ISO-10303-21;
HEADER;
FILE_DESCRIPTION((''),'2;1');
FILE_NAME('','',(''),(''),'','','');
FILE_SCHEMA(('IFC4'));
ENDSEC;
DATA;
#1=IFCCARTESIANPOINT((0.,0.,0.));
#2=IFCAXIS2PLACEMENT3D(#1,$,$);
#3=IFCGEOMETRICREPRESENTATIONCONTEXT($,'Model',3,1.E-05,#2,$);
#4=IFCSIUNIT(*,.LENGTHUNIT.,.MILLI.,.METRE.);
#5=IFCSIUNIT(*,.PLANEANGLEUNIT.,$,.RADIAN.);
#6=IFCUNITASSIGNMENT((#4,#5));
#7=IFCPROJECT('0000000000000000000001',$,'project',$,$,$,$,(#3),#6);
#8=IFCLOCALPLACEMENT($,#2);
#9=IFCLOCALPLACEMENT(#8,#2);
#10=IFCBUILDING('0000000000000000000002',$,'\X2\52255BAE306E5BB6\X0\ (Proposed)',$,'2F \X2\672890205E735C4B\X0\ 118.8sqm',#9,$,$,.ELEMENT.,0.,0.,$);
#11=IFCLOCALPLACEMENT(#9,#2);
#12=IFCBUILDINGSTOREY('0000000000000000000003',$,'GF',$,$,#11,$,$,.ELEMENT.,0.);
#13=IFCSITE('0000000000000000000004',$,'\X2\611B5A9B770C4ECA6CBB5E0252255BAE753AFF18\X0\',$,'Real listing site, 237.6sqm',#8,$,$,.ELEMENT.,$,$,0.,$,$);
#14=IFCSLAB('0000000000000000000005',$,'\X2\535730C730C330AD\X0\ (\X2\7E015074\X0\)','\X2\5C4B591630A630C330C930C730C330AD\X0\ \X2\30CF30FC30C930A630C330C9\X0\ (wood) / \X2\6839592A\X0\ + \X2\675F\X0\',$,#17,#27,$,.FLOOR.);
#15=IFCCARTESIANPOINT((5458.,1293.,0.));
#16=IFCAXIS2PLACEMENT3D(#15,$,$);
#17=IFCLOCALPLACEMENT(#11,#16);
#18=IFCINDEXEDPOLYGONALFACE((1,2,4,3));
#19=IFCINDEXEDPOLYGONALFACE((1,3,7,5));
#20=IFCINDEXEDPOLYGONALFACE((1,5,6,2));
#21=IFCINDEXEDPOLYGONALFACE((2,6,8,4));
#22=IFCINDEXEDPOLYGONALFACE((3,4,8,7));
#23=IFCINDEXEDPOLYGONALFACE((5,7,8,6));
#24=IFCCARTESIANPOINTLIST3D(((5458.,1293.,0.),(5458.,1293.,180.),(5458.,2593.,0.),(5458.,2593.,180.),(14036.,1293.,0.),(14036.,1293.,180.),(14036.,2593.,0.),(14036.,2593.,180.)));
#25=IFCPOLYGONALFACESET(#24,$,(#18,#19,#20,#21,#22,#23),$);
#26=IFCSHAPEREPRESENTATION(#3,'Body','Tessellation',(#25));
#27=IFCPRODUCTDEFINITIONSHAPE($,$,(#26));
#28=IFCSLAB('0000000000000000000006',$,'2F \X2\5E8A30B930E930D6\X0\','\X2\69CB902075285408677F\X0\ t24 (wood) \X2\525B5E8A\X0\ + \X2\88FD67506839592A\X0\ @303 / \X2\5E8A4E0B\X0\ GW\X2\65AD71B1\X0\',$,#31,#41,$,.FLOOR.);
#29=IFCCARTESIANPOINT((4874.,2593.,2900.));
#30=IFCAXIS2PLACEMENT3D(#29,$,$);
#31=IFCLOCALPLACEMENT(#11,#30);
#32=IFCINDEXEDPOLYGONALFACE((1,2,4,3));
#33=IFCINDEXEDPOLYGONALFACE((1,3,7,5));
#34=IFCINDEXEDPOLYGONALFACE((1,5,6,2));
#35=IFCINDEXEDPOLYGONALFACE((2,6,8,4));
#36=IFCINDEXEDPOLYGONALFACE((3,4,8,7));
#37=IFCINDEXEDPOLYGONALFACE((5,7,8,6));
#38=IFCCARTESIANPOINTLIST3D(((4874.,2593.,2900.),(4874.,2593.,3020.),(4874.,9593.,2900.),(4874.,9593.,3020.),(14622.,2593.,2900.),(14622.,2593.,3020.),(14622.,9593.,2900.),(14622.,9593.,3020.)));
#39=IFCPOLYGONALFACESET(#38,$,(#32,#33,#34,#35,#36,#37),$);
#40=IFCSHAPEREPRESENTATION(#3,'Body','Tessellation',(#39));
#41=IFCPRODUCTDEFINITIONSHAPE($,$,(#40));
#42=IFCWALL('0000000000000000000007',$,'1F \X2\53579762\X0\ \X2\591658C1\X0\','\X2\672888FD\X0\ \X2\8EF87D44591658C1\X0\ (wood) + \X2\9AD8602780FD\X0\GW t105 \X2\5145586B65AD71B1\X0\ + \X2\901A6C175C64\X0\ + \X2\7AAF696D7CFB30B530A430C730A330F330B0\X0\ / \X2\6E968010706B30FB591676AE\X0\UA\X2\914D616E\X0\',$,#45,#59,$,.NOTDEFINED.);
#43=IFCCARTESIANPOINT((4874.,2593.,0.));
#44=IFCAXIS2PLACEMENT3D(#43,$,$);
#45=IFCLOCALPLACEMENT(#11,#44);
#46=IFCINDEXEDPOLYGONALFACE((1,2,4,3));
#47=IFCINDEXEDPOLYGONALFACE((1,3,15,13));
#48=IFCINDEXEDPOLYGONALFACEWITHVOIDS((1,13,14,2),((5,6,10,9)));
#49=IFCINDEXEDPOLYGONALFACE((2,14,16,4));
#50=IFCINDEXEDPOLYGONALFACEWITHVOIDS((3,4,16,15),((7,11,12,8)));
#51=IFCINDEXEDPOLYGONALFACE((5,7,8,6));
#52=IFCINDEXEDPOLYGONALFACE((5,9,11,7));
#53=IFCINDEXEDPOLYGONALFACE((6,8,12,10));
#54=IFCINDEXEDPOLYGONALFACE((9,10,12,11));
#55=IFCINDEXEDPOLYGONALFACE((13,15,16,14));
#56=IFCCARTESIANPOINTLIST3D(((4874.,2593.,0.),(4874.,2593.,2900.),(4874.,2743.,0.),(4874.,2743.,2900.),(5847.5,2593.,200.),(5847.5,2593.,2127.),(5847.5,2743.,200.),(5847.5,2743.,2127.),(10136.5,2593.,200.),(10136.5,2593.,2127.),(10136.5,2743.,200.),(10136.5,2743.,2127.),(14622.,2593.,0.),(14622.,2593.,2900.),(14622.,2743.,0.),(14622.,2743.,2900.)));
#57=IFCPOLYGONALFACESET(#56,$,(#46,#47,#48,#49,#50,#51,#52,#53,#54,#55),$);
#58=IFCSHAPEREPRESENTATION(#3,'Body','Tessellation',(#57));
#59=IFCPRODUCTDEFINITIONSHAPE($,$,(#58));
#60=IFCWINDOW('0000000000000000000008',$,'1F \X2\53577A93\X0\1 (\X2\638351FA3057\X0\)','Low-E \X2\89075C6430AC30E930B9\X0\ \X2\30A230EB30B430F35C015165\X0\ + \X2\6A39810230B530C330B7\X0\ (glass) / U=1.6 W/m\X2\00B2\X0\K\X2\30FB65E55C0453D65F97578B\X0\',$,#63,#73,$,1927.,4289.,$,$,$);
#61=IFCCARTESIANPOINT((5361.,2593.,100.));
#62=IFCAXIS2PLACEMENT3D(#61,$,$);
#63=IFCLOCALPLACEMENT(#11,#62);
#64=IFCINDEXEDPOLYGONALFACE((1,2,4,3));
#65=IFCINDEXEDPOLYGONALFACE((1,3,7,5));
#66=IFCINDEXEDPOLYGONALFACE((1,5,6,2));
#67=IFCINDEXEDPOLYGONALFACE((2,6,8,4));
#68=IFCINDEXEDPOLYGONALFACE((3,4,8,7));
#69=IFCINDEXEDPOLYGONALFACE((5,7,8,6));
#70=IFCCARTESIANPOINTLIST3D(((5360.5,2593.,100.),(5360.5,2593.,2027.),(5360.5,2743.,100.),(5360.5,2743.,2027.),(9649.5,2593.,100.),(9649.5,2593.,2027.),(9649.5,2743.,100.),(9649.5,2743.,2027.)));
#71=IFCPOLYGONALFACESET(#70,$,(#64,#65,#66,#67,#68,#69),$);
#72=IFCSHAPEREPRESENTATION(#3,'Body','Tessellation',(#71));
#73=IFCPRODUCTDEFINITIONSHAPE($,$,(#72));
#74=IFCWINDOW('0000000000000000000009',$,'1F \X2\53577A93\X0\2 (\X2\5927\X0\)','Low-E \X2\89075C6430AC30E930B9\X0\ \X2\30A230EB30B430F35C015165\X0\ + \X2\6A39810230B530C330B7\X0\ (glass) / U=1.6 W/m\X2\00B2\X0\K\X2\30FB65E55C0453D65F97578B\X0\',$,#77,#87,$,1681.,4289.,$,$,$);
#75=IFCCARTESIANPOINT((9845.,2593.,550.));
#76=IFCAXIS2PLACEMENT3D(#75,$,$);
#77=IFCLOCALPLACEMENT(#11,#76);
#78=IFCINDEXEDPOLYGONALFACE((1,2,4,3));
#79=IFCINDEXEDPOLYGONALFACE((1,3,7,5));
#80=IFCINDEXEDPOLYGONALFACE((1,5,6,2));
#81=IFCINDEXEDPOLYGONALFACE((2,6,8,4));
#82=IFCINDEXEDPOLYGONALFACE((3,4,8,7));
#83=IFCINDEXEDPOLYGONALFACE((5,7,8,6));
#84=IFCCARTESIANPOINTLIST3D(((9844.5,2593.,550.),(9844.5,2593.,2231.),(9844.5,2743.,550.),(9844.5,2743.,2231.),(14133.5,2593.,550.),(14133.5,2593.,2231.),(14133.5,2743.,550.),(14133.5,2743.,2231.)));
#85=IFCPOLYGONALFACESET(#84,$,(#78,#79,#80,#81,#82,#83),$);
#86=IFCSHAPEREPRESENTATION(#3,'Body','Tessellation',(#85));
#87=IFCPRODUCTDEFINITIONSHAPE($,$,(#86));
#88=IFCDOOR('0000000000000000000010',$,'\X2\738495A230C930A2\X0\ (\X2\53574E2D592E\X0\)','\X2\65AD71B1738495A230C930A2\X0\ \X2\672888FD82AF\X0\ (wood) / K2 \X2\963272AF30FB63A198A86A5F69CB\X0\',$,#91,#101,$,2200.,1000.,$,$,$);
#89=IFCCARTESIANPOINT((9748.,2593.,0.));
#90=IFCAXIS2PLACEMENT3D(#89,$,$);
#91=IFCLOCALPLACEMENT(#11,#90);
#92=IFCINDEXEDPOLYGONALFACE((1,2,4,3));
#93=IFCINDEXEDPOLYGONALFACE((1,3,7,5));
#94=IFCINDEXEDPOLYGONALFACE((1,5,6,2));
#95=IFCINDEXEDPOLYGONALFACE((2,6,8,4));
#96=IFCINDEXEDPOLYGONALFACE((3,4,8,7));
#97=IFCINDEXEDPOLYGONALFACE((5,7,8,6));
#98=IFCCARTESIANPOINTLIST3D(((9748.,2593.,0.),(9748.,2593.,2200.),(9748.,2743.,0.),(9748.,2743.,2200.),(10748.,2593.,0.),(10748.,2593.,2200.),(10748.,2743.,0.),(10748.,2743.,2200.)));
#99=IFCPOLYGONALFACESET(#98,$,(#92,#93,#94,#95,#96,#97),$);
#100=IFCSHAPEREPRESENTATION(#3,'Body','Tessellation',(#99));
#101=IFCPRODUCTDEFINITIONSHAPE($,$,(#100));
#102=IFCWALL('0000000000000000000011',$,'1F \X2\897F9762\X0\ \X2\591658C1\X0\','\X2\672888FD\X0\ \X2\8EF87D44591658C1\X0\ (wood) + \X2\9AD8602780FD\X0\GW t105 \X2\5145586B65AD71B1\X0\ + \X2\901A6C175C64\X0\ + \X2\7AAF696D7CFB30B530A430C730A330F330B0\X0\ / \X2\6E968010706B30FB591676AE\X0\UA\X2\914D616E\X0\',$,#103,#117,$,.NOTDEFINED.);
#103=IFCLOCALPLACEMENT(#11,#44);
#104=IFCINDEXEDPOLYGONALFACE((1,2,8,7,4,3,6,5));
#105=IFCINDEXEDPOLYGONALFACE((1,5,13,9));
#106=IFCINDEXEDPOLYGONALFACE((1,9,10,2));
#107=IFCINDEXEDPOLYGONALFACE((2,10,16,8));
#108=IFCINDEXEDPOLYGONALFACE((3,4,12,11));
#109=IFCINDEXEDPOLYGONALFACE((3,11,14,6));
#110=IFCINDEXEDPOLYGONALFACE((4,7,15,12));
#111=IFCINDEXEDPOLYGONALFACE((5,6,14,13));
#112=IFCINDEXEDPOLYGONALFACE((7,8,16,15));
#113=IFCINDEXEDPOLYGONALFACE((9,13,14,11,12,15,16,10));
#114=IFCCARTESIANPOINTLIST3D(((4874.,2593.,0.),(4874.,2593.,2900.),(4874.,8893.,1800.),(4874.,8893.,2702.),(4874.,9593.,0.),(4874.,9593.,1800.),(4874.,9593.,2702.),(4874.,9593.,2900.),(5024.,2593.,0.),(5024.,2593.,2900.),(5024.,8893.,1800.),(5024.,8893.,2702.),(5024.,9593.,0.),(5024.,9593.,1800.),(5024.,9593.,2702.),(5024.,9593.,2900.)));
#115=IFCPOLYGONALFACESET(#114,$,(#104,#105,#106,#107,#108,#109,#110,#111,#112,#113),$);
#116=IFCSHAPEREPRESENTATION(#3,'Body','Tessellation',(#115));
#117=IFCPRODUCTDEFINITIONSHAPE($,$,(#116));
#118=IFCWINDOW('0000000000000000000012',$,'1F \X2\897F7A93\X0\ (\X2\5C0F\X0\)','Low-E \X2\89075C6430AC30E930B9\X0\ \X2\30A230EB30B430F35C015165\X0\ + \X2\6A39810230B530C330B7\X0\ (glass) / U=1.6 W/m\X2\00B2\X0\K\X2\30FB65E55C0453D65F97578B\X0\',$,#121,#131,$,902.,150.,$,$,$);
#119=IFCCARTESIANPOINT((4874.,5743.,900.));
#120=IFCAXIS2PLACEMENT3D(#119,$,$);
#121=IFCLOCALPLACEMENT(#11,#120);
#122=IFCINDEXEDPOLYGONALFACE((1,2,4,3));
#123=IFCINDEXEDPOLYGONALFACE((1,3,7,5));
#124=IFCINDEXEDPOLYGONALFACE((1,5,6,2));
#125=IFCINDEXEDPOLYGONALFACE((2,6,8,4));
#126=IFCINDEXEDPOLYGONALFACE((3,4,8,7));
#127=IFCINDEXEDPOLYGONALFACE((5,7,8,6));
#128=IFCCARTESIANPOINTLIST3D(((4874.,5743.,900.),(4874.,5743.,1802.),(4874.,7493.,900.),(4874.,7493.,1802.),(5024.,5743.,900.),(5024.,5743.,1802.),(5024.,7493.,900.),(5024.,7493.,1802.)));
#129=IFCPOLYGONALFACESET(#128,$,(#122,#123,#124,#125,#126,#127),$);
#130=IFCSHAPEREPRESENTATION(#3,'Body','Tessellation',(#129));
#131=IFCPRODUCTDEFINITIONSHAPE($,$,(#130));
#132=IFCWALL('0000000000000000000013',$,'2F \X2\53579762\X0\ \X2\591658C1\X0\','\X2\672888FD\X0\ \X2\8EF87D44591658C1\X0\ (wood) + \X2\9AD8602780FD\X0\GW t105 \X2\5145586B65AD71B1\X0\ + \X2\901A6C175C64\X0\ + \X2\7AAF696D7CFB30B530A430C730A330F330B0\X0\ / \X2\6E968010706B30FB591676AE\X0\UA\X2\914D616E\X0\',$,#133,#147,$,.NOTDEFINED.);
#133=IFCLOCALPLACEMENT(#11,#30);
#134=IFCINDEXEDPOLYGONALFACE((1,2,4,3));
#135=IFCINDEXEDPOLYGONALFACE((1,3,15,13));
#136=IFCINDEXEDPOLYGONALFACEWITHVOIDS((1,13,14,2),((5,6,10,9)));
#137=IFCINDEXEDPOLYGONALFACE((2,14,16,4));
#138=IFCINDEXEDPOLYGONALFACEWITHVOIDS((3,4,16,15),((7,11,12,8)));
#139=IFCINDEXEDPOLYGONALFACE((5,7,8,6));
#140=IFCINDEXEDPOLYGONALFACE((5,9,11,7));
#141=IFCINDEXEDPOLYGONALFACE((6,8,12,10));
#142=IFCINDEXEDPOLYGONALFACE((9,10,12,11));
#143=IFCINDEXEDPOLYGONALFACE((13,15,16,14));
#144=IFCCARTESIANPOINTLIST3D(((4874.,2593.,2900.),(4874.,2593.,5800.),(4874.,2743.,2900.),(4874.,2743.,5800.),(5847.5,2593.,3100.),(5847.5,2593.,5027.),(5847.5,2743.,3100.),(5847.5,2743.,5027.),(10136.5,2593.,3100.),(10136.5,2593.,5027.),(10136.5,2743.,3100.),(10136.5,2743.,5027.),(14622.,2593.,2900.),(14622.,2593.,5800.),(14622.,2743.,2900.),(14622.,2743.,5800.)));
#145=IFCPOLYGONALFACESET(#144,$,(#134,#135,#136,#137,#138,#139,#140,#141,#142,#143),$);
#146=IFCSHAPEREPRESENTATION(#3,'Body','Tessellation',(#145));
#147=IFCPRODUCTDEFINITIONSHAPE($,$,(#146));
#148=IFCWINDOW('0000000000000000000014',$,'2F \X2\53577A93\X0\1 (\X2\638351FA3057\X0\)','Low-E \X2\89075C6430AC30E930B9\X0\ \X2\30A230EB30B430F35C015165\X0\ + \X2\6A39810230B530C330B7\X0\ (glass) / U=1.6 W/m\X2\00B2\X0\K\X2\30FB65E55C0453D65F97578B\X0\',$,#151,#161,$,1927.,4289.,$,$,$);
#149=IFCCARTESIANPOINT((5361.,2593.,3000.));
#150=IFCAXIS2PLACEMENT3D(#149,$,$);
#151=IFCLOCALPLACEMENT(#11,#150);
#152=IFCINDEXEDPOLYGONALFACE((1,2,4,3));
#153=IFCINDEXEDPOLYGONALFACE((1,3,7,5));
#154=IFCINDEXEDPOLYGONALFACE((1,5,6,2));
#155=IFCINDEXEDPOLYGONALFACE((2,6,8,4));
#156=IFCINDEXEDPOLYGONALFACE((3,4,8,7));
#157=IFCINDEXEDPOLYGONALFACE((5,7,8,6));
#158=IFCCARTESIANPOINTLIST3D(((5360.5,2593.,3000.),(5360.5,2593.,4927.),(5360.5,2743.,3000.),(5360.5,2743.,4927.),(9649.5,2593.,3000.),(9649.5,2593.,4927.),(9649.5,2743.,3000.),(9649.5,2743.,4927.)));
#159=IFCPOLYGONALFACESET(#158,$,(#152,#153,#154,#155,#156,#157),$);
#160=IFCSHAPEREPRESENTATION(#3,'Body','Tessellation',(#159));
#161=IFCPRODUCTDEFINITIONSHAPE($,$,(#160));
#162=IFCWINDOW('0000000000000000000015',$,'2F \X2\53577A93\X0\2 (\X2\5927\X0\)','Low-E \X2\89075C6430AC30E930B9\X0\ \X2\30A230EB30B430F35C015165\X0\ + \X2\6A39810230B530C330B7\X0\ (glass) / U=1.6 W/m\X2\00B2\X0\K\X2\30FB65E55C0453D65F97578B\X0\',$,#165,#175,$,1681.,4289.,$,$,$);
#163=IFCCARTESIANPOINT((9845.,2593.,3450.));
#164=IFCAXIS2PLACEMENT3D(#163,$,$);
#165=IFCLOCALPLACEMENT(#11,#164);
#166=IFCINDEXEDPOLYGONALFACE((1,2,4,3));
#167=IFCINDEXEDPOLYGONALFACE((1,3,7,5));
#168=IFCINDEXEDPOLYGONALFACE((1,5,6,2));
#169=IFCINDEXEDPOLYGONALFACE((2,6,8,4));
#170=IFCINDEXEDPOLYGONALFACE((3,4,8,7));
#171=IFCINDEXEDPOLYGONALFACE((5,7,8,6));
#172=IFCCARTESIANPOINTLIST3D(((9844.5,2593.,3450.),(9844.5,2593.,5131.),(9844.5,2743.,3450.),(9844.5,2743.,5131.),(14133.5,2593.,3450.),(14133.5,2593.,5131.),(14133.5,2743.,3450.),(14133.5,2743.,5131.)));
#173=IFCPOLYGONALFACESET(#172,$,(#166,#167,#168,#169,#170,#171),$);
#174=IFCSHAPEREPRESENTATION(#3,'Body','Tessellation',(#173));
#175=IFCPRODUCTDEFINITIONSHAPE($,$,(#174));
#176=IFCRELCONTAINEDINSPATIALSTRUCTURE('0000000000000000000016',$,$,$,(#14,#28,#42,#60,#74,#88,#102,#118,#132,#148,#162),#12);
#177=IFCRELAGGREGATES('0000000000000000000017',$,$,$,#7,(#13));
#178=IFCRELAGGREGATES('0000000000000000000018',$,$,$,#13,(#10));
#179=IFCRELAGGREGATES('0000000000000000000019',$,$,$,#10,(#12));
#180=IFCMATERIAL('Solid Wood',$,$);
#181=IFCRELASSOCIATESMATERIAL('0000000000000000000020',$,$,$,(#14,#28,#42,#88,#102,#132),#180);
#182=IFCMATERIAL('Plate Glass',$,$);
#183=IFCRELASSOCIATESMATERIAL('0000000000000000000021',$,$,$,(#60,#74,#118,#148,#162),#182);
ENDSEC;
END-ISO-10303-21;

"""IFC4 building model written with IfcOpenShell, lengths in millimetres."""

from ifc_helpers import new_model, si_unit, frame, frame_2d, origin, place, context, project, spatial, rectangle, extrude, material, element, fill, save


model = new_model("IFC4")

# Units and contexts
model_context = context("Model", 3, precision=1e-05, world=origin())
ifc_project = project(units=[si_unit("LENGTHUNIT", "METRE", prefix="MILLI"), si_unit("PLANEANGLEUNIT", "RADIAN")], contexts=[model_context])

# Site, building, storey
site_placement = place(None, origin())
site = spatial("IfcSite", under=ifc_project, at=site_placement, Name="愛媛県今治市別宮町８", ObjectType="Real listing site, 237.6sqm", CompositionType="ELEMENT", RefElevation=0.0)
building_placement = place(site_placement, origin())
building = spatial("IfcBuilding", under=site, at=building_placement, Name="別宮の家 (Proposed)", ObjectType="2F 木造平屋 118.8sqm", CompositionType="ELEMENT", ElevationOfRefHeight=0.0, ElevationOfTerrain=0.0)
storey_placement = place(building_placement, origin())
storey = spatial("IfcBuildingStorey", under=building, at=storey_placement, Name="GF", CompositionType="ELEMENT", Elevation=0.0)

# Slabs
ifc_material_1 = material(Name="Solid Wood")
slab_1_placement = place(storey_placement, frame((5458.0, 1293.0, 0.0)))
element("IfcSlab", 1, at=slab_1_placement, inside=storey, material=ifc_material_1, Name="南デッキ (縁側)", Description="屋外ウッドデッキ ハードウッド (wood) / 根太 + 束", PredefinedType="FLOOR", context=model_context, shape_type="SweptSolid", body=[
    extrude(rectangle(XDim=8578.0, YDim=1300.0, at=frame_2d((4289.0, 650.0))), frame((5458.0, 1293.0, 0.0)), (0.0, 0.0, 1.0), 180.0),
])
slab_2_placement = place(storey_placement, frame((4874.0, 2593.0, 2900.0)))
element("IfcSlab", 2, at=slab_2_placement, inside=storey, material=ifc_material_1, Name="2F 床スラブ", Description="構造用合板 t24 (wood) 剛床 + 製材根太 @303 / 床下 GW断熱", PredefinedType="FLOOR", context=model_context, shape_type="SweptSolid", body=[
    extrude(rectangle(XDim=9748.0, YDim=7000.0, at=frame_2d((4874.0, 3500.0))), frame((4874.0, 2593.0, 2900.0)), (0.0, 0.0, 1.0), 120.0),
])

# Wall, openings, windows, door
wall_1_placement = place(storey_placement, frame((4874.0, 2593.0, 0.0)))
wall_1 = element("IfcWall", 3, at=wall_1_placement, inside=storey, material=ifc_material_1, Name="1F 南面 外壁", Description="木製 軸組外壁 (wood) + 高性能GW t105 充填断熱 + 通気層 + 窯業系サイディング / 準耐火・外皮UA配慮", PredefinedType="NOTDEFINED", context=model_context, shape_type="SweptSolid", body=[
    extrude(rectangle(XDim=9748.0, YDim=150.0, at=frame_2d((4874.0, 75.0))), frame((4874.0, 2593.0, 0.0)), (0.0, 0.0, 1.0), 2900.0),
])
opening_1_placement = place(storey_placement, frame((5361.0, 2593.0, 100.0)))
opening_1 = element("IfcOpeningElement", 4, at=opening_1_placement, cuts=wall_1, PredefinedType="NOTDEFINED", context=model_context, shape_type="SweptSolid", body=[
    extrude(rectangle(XDim=4289.0, YDim=150.0, at=frame_2d((2144.0, 75.0))), frame((5361.0, 2593.0, 100.0)), (0.0, 0.0, 1.0), 1927.0),
])
opening_2_placement = place(storey_placement, frame((9845.0, 2593.0, 550.0)))
opening_2 = element("IfcOpeningElement", 5, at=opening_2_placement, cuts=wall_1, PredefinedType="NOTDEFINED", context=model_context, shape_type="SweptSolid", body=[
    extrude(rectangle(XDim=4289.0, YDim=150.0, at=frame_2d((2144.0, 75.0))), frame((9845.0, 2593.0, 550.0)), (0.0, 0.0, 1.0), 1681.0),
])
opening_3_placement = place(storey_placement, frame((9748.0, 2593.0, 0.0)))
opening_3 = element("IfcOpeningElement", 6, at=opening_3_placement, cuts=wall_1, PredefinedType="NOTDEFINED", context=model_context, shape_type="SweptSolid", body=[
    extrude(rectangle(XDim=1000.0, YDim=150.0, at=frame_2d((500.0, 75.0))), frame((9748.0, 2593.0, 0.0)), (0.0, 0.0, 1.0), 2200.0),
])
ifc_material_2 = material(Name="Plate Glass")
window_1_placement = place(storey_placement, frame((5361.0, 2593.0, 100.0)))
window_1 = element("IfcWindow", 7, at=window_1_placement, inside=storey, material=ifc_material_2, Name="1F 南窓1 (掃出し)", Description="Low-E 複層ガラス アルゴン封入 + 樹脂サッシ (glass) / U=1.6 W/m²K・日射取得型", OverallHeight=1927.0, OverallWidth=4289.0, context=model_context, shape_type="SweptSolid", body=[
    extrude(rectangle(XDim=4289.0, YDim=150.0, at=frame_2d((2144.0, 75.0))), frame((5361.0, 2593.0, 100.0)), (0.0, 0.0, 1.0), 1927.0),
])
fill(opening_1, window_1)
window_2_placement = place(storey_placement, frame((9845.0, 2593.0, 550.0)))
window_2 = element("IfcWindow", 8, at=window_2_placement, inside=storey, material=ifc_material_2, Name="1F 南窓2 (大)", Description="Low-E 複層ガラス アルゴン封入 + 樹脂サッシ (glass) / U=1.6 W/m²K・日射取得型", OverallHeight=1681.0, OverallWidth=4289.0, context=model_context, shape_type="SweptSolid", body=[
    extrude(rectangle(XDim=4289.0, YDim=150.0, at=frame_2d((2144.0, 75.0))), frame((9845.0, 2593.0, 550.0)), (0.0, 0.0, 1.0), 1681.0),
])
fill(opening_2, window_2)
door_placement = place(storey_placement, frame((9748.0, 2593.0, 0.0)))
door = element("IfcDoor", 9, at=door_placement, inside=storey, material=ifc_material_1, Name="玄関ドア (南中央)", Description="断熱玄関ドア 木製芯 (wood) / K2 防犯・採風機構", OverallHeight=2200.0, OverallWidth=1000.0, context=model_context, shape_type="SweptSolid", body=[
    extrude(rectangle(XDim=1000.0, YDim=150.0, at=frame_2d((500.0, 75.0))), frame((9748.0, 2593.0, 0.0)), (0.0, 0.0, 1.0), 2200.0),
])
fill(opening_3, door)

# Wall, opening, window
wall_2_placement = place(storey_placement, frame((4874.0, 2593.0, 0.0)))
wall_2 = element("IfcWall", 10, at=wall_2_placement, inside=storey, material=ifc_material_1, Name="1F 西面 外壁", Description="木製 軸組外壁 (wood) + 高性能GW t105 充填断熱 + 通気層 + 窯業系サイディング / 準耐火・外皮UA配慮", PredefinedType="NOTDEFINED", context=model_context, shape_type="SweptSolid", body=[
    extrude(rectangle(XDim=150.0, YDim=7000.0, at=frame_2d((75.0, 3500.0))), frame((4874.0, 2593.0, 0.0)), (0.0, 0.0, 1.0), 2900.0),
])
opening_4_placement = place(storey_placement, frame((4874.0, 5743.0, 900.0)))
opening_4 = element("IfcOpeningElement", 11, at=opening_4_placement, cuts=wall_2, PredefinedType="NOTDEFINED", context=model_context, shape_type="SweptSolid", body=[
    extrude(rectangle(XDim=150.0, YDim=1750.0, at=frame_2d((75.0, 875.0))), frame((4874.0, 5743.0, 900.0)), (0.0, 0.0, 1.0), 902.0),
])
window_3_placement = place(storey_placement, frame((4874.0, 5743.0, 900.0)))
window_3 = element("IfcWindow", 12, at=window_3_placement, inside=storey, material=ifc_material_2, Name="1F 西窓 (小)", Description="Low-E 複層ガラス アルゴン封入 + 樹脂サッシ (glass) / U=1.6 W/m²K・日射取得型", OverallHeight=902.0, OverallWidth=150.0, context=model_context, shape_type="SweptSolid", body=[
    extrude(rectangle(XDim=150.0, YDim=1750.0, at=frame_2d((75.0, 875.0))), frame((4874.0, 5743.0, 900.0)), (0.0, 0.0, 1.0), 902.0),
])
fill(opening_4, window_3)

# Wall, openings, windows
wall_3_placement = place(storey_placement, frame((4874.0, 2593.0, 2900.0)))
wall_3 = element("IfcWall", 13, at=wall_3_placement, inside=storey, material=ifc_material_1, Name="2F 南面 外壁", Description="木製 軸組外壁 (wood) + 高性能GW t105 充填断熱 + 通気層 + 窯業系サイディング / 準耐火・外皮UA配慮", PredefinedType="NOTDEFINED", context=model_context, shape_type="SweptSolid", body=[
    extrude(rectangle(XDim=9748.0, YDim=150.0, at=frame_2d((4874.0, 75.0))), frame((4874.0, 2593.0, 2900.0)), (0.0, 0.0, 1.0), 2900.0),
])
opening_5_placement = place(storey_placement, frame((5361.0, 2593.0, 3000.0)))
opening_5 = element("IfcOpeningElement", 14, at=opening_5_placement, cuts=wall_3, PredefinedType="NOTDEFINED", context=model_context, shape_type="SweptSolid", body=[
    extrude(rectangle(XDim=4289.0, YDim=150.0, at=frame_2d((2144.0, 75.0))), frame((5361.0, 2593.0, 3000.0)), (0.0, 0.0, 1.0), 1927.0),
])
opening_6_placement = place(storey_placement, frame((9845.0, 2593.0, 3450.0)))
opening_6 = element("IfcOpeningElement", 15, at=opening_6_placement, cuts=wall_3, PredefinedType="NOTDEFINED", context=model_context, shape_type="SweptSolid", body=[
    extrude(rectangle(XDim=4289.0, YDim=150.0, at=frame_2d((2144.0, 75.0))), frame((9845.0, 2593.0, 3450.0)), (0.0, 0.0, 1.0), 1681.0),
])
window_4_placement = place(storey_placement, frame((5361.0, 2593.0, 3000.0)))
window_4 = element("IfcWindow", 16, at=window_4_placement, inside=storey, material=ifc_material_2, Name="2F 南窓1 (掃出し)", Description="Low-E 複層ガラス アルゴン封入 + 樹脂サッシ (glass) / U=1.6 W/m²K・日射取得型", OverallHeight=1927.0, OverallWidth=4289.0, context=model_context, shape_type="SweptSolid", body=[
    extrude(rectangle(XDim=4289.0, YDim=150.0, at=frame_2d((2144.0, 75.0))), frame((5361.0, 2593.0, 3000.0)), (0.0, 0.0, 1.0), 1927.0),
])
fill(opening_5, window_4)
window_5_placement = place(storey_placement, frame((9845.0, 2593.0, 3450.0)))
window_5 = element("IfcWindow", 17, at=window_5_placement, inside=storey, material=ifc_material_2, Name="2F 南窓2 (大)", Description="Low-E 複層ガラス アルゴン封入 + 樹脂サッシ (glass) / U=1.6 W/m²K・日射取得型", OverallHeight=1681.0, OverallWidth=4289.0, context=model_context, shape_type="SweptSolid", body=[
    extrude(rectangle(XDim=4289.0, YDim=150.0, at=frame_2d((2144.0, 75.0))), frame((9845.0, 2593.0, 3450.0)), (0.0, 0.0, 1.0), 1681.0),
])
fill(opening_6, window_5)

save(model, "model.ifc")
